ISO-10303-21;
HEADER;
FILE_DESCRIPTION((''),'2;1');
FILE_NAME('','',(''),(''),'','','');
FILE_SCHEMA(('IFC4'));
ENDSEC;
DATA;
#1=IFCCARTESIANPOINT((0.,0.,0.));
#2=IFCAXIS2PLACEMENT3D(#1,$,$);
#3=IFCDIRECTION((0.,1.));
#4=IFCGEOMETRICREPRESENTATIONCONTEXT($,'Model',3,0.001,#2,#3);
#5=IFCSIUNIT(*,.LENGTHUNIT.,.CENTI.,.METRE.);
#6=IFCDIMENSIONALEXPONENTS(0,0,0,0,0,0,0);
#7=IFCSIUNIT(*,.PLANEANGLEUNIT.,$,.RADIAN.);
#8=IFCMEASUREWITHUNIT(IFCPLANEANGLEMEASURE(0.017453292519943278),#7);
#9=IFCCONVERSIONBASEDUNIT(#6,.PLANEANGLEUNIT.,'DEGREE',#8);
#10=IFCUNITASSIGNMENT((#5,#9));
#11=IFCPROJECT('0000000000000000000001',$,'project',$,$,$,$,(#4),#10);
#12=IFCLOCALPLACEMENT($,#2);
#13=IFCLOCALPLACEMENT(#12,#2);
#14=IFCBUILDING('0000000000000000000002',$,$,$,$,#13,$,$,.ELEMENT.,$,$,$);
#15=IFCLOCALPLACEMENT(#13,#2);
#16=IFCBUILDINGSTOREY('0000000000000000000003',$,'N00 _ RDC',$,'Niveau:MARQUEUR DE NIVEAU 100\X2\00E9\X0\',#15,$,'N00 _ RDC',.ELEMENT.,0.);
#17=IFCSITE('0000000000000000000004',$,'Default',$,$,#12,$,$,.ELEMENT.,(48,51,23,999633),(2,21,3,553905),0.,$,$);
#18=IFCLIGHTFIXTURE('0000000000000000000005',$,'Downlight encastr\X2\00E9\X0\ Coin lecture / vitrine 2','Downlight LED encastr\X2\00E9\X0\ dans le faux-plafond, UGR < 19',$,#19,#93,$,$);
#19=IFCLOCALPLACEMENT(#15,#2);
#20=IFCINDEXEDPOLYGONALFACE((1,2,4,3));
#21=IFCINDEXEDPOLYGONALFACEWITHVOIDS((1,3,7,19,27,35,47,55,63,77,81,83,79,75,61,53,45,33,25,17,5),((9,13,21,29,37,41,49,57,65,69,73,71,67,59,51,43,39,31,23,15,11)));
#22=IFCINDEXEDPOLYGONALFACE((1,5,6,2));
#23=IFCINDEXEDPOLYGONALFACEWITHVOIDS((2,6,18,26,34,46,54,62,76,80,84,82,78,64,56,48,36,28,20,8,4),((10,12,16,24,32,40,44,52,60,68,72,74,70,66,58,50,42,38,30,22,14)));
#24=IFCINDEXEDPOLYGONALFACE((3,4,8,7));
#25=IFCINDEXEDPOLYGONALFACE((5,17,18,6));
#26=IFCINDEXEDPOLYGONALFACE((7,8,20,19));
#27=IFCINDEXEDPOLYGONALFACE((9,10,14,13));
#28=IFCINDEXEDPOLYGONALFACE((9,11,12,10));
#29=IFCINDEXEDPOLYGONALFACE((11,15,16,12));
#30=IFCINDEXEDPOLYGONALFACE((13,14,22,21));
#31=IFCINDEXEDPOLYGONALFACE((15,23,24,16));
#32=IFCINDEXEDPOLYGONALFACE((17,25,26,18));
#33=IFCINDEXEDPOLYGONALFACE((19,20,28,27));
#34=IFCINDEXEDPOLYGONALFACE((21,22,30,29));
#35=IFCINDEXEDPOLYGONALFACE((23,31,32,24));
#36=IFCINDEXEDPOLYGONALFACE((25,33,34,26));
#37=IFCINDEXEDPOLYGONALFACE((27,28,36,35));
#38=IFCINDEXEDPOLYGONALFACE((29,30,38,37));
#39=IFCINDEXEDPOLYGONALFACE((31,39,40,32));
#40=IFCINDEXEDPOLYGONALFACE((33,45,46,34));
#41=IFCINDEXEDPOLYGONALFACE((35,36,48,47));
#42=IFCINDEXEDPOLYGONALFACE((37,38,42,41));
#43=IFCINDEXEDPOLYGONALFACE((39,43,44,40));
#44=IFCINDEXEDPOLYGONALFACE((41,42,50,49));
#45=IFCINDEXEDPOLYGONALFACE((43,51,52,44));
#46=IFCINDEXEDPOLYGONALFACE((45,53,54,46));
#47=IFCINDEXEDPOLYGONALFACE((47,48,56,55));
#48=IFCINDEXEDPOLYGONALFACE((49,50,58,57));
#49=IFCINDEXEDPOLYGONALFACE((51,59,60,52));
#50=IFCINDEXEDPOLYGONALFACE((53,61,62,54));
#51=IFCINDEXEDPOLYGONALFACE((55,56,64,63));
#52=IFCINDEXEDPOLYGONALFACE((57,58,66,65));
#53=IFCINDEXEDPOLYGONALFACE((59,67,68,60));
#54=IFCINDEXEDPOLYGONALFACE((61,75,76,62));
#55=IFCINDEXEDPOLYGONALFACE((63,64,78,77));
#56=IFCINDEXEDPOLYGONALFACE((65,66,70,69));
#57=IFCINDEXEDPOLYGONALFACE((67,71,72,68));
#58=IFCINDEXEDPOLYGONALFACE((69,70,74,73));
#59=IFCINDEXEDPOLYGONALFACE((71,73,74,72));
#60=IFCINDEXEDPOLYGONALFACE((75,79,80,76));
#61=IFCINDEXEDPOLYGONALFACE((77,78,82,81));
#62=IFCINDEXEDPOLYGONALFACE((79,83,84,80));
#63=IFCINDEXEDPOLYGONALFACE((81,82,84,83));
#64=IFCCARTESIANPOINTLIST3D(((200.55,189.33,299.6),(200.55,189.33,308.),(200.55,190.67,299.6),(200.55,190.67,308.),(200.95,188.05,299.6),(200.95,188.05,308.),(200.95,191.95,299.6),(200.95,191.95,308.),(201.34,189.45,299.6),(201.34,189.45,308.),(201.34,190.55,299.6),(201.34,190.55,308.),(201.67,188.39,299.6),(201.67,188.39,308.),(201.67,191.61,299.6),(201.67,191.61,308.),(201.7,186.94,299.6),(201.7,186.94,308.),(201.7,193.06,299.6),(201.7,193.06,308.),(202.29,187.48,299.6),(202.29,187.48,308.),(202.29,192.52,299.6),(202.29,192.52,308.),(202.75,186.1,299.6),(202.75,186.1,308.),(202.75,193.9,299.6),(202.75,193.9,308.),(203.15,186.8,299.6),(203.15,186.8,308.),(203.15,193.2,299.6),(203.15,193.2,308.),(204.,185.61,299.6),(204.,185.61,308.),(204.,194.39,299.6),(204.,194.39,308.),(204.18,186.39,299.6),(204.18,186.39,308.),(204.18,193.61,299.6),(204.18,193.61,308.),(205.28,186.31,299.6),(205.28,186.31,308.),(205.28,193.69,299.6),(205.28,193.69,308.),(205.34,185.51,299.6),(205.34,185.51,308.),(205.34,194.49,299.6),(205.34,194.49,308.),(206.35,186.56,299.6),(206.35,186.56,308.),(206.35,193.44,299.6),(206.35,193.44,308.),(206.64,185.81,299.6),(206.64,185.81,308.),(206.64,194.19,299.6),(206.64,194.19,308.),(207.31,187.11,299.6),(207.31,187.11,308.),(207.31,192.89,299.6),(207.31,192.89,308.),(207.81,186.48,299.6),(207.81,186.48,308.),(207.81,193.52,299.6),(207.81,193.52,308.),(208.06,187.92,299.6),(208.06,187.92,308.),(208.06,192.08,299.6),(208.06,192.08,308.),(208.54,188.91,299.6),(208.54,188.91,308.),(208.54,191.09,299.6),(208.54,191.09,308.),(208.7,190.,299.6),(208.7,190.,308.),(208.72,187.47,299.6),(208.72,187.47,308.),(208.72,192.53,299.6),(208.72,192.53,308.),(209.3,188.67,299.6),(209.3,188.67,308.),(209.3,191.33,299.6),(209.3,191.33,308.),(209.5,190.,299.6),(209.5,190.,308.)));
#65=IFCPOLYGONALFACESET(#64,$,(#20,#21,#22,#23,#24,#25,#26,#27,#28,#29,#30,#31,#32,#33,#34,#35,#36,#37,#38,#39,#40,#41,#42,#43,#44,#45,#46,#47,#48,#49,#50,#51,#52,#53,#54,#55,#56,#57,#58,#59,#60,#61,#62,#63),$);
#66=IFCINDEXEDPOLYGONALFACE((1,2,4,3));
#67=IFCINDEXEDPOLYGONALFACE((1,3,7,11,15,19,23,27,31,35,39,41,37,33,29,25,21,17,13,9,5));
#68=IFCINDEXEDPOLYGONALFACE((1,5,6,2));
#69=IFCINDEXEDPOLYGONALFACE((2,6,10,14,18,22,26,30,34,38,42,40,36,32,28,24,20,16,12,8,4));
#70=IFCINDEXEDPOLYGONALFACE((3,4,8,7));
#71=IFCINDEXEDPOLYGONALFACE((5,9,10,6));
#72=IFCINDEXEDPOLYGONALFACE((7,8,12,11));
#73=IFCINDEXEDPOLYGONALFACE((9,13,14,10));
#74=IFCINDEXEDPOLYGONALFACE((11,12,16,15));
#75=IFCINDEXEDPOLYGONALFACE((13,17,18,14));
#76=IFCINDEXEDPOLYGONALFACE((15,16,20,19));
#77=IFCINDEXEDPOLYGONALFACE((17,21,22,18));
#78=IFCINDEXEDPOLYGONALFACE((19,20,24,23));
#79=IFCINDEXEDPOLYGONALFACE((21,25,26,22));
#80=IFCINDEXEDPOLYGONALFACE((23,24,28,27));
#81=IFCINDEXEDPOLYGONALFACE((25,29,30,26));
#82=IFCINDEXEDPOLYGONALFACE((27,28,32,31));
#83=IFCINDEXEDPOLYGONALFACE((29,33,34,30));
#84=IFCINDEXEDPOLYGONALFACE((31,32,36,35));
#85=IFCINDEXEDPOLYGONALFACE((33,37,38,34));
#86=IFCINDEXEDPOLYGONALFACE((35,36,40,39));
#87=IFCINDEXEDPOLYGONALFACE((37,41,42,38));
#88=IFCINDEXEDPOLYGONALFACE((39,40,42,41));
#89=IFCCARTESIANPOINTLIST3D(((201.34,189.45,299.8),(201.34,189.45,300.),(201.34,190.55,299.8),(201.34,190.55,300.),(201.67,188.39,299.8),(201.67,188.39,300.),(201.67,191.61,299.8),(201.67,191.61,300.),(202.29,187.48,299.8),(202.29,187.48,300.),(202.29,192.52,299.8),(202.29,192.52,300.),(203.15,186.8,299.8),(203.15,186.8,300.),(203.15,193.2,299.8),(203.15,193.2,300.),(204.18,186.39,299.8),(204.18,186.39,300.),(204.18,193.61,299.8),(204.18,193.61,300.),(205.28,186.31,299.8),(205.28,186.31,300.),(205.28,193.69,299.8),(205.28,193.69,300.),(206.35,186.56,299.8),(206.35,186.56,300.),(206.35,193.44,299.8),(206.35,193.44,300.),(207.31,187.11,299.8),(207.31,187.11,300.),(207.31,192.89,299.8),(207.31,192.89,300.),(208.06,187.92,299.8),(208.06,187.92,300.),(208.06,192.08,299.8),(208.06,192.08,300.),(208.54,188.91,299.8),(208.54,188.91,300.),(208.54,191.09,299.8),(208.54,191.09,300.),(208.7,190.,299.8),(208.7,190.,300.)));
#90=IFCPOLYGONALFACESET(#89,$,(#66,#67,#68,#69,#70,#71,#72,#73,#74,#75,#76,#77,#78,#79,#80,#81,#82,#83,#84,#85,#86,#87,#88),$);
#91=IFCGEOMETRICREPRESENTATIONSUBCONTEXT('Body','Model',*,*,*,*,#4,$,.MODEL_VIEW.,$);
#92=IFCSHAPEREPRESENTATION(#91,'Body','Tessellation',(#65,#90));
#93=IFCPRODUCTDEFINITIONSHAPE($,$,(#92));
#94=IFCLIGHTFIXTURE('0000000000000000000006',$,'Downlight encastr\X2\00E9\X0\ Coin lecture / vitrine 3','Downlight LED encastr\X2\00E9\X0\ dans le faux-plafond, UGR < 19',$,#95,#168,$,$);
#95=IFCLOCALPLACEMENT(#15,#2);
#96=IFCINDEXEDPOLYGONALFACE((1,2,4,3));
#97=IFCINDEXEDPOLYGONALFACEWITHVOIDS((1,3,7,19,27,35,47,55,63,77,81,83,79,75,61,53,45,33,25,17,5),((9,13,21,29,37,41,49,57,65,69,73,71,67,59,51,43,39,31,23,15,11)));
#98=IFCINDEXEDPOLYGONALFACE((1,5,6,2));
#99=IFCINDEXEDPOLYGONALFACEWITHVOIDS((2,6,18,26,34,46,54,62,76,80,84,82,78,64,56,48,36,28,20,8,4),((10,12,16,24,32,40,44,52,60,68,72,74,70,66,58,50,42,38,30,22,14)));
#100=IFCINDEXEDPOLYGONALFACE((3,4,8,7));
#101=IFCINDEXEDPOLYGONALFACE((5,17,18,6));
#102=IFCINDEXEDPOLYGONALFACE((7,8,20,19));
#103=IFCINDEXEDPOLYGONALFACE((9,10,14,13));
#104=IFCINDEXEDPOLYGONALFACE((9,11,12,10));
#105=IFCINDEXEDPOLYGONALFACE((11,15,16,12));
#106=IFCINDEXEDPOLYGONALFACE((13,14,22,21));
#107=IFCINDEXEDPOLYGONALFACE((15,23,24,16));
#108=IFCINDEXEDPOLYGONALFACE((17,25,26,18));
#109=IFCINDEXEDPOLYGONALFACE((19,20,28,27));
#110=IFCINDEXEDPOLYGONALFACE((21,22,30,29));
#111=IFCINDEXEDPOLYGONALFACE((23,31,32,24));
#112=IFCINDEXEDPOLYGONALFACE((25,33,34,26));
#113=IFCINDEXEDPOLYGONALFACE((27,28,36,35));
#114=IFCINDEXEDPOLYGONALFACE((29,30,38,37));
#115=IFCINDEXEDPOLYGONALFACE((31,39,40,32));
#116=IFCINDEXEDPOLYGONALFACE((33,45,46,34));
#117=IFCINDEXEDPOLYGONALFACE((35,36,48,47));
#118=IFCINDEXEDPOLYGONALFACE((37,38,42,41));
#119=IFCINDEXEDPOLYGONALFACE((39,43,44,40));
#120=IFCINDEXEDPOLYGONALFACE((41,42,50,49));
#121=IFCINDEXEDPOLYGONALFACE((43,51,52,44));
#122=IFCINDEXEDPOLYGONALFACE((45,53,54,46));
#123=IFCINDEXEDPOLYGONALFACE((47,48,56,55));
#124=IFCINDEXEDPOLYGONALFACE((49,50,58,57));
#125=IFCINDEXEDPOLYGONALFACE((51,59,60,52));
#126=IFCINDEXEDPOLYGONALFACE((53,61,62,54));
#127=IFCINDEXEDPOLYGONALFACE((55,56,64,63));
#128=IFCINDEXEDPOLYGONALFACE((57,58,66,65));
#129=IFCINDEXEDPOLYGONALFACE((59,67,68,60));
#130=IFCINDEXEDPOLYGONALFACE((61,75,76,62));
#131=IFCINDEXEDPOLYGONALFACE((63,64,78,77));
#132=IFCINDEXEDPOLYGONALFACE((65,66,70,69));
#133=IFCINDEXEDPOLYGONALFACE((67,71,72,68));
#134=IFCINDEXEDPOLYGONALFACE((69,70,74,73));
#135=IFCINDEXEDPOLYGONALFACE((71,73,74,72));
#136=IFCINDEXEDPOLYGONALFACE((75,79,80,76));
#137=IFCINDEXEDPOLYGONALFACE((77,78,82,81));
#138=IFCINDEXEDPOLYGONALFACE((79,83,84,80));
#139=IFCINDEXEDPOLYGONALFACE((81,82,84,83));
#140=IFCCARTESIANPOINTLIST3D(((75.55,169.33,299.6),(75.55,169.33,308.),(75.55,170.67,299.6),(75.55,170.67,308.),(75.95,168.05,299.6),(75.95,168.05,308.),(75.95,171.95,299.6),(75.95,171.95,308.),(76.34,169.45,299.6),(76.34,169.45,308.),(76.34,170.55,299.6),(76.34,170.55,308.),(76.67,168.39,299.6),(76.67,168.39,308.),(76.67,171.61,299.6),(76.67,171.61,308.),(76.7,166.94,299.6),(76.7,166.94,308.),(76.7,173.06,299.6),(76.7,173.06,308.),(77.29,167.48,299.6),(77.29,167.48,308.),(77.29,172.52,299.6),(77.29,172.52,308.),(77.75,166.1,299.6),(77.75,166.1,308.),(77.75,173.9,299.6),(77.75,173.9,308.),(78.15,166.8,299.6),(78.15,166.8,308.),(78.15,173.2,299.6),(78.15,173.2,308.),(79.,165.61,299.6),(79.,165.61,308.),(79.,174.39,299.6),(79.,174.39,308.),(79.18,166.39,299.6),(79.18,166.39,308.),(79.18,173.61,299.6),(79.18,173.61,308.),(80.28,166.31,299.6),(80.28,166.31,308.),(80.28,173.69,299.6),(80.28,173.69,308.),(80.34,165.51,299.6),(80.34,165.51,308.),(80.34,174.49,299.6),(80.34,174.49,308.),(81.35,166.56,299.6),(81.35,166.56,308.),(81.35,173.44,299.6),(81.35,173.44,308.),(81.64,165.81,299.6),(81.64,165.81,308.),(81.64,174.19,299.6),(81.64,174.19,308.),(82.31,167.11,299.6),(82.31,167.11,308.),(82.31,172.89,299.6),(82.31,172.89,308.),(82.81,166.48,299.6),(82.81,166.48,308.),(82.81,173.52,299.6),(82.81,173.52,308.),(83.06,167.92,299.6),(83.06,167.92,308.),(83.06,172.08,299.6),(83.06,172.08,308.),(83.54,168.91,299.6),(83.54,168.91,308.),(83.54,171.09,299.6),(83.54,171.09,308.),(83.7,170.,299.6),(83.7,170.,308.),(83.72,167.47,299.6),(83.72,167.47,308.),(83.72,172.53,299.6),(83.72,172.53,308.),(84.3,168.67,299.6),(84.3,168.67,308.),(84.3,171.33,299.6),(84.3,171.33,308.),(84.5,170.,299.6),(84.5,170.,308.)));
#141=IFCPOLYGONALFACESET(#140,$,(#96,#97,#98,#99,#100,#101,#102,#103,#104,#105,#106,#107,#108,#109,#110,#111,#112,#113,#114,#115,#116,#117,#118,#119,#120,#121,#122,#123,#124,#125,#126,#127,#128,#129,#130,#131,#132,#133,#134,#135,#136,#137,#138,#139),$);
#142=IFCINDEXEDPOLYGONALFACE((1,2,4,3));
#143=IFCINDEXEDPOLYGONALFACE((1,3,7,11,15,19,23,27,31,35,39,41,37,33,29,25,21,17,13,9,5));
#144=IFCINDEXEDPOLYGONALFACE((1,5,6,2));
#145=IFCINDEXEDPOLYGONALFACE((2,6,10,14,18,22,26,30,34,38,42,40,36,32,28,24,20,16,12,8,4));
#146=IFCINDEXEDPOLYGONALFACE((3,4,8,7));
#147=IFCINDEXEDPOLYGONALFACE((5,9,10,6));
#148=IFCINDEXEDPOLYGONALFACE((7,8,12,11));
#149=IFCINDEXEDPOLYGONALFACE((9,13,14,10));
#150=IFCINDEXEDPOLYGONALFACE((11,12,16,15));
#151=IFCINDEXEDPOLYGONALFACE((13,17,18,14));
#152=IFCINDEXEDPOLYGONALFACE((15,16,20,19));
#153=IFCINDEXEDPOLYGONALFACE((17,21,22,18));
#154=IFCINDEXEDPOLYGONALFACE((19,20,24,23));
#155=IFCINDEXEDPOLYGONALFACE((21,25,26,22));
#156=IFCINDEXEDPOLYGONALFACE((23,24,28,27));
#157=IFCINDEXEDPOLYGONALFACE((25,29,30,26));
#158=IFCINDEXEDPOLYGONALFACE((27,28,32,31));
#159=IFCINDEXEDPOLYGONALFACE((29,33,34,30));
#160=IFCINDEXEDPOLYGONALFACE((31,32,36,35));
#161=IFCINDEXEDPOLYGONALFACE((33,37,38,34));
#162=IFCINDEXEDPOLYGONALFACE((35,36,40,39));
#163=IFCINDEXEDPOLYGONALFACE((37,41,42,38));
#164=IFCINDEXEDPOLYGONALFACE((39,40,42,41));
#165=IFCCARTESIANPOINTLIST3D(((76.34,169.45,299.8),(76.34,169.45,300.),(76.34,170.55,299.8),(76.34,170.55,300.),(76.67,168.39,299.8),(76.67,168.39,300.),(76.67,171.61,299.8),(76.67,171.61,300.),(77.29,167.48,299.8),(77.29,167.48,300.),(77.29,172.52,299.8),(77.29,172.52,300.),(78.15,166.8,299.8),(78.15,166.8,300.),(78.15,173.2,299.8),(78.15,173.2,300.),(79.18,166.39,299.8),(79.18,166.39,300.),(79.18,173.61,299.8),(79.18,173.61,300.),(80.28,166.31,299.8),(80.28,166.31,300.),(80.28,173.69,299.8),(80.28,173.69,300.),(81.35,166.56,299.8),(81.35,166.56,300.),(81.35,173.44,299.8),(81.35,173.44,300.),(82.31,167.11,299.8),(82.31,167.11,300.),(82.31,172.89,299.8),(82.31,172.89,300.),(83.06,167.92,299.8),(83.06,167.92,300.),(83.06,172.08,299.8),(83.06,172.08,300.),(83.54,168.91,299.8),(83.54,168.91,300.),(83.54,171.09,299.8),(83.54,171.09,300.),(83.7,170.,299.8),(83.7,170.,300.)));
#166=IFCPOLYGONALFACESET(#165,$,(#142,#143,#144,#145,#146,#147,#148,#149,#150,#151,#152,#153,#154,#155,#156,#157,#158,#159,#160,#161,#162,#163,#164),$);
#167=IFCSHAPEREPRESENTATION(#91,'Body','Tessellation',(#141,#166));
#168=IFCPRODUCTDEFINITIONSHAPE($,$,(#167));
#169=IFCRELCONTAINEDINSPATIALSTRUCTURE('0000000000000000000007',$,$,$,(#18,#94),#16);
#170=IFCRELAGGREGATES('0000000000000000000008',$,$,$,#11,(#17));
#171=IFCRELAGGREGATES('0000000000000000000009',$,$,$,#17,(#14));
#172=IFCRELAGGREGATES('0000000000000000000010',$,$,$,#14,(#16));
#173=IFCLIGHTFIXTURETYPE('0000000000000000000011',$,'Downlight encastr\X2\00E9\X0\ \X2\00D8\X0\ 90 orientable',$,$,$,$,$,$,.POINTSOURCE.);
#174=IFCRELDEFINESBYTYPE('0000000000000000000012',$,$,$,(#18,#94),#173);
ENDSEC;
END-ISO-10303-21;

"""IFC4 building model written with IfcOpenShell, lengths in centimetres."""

from ifc_helpers import new_model, entity, si_unit, converted_unit, direction, frame, frame_2d, origin, origin_with_axes, place, context, subcontext, project, spatial, circle, hollow_circle, extrude, type_object, element, save


model = new_model("IFC4")

# Units and contexts
model_context = context("Model", 3, precision=0.001, world=origin(), true_north=direction((0.0, 1.0)))
body_context = subcontext(model_context, "Body", "Model", "MODEL_VIEW")
ifc_project = project(units=[si_unit("LENGTHUNIT", "METRE", prefix="CENTI"), converted_unit("PLANEANGLEUNIT", "DEGREE", entity("IfcPlaneAngleMeasure", 0.017453292519943278), si_unit("PLANEANGLEUNIT", "RADIAN"), dimensions=[0, 0, 0, 0, 0, 0, 0])], contexts=[model_context])

# Site, building, storey
site_placement = place(None, origin())
site = spatial("IfcSite", under=ifc_project, at=site_placement, Name="Default", CompositionType="ELEMENT", RefLatitude=(48, 51, 23, 999633), RefLongitude=(2, 21, 3, 553905), RefElevation=0.0)
building_placement = place(site_placement, origin())
building = spatial("IfcBuilding", under=site, at=building_placement, CompositionType="ELEMENT")
storey_placement = place(building_placement, origin())
storey = spatial("IfcBuildingStorey", under=building, at=storey_placement, Name="N00 _ RDC", ObjectType="Niveau:MARQUEUR DE NIVEAU 100é", LongName="N00 _ RDC", CompositionType="ELEMENT", Elevation=0.0)

# Light fixtures
light_fixture_type_1 = type_object("IfcLightFixtureType", Name="Downlight encastré Ø 90 orientable", PredefinedType="POINTSOURCE")
light_fixture_1_placement = place(storey_placement, origin_with_axes())
element("IfcLightFixture", 1, at=light_fixture_1_placement, inside=storey, type_object=light_fixture_type_1, Name="Downlight encastré Coin lecture / vitrine 2", Description="Downlight LED encastré dans le faux-plafond, UGR < 19", context=body_context, shape_type="SweptSolid", body=[
    extrude(hollow_circle(Radius=4.5, WallThickness=0.8, at=frame_2d((205.0, 190.0))), frame((0.0, 0.0, 299.6)), (0.0, 0.0, 1.0), 8.4),
    extrude(circle(Radius=3.7, at=frame_2d((205.0, 190.0))), frame((0.0, 0.0, 299.8)), (0.0, 0.0, 1.0), 0.2),
])
light_fixture_2_placement = place(storey_placement, origin_with_axes())
element("IfcLightFixture", 2, at=light_fixture_2_placement, inside=storey, type_object=light_fixture_type_1, Name="Downlight encastré Coin lecture / vitrine 3", Description="Downlight LED encastré dans le faux-plafond, UGR < 19", context=body_context, shape_type="SweptSolid", body=[
    extrude(hollow_circle(Radius=4.5, WallThickness=0.8, at=frame_2d((80.0, 170.0))), frame((0.0, 0.0, 299.6)), (0.0, 0.0, 1.0), 8.4),
    extrude(circle(Radius=3.7, at=frame_2d((80.0, 170.0))), frame((0.0, 0.0, 299.8)), (0.0, 0.0, 1.0), 0.2),
])

save(model, "model.ifc")
